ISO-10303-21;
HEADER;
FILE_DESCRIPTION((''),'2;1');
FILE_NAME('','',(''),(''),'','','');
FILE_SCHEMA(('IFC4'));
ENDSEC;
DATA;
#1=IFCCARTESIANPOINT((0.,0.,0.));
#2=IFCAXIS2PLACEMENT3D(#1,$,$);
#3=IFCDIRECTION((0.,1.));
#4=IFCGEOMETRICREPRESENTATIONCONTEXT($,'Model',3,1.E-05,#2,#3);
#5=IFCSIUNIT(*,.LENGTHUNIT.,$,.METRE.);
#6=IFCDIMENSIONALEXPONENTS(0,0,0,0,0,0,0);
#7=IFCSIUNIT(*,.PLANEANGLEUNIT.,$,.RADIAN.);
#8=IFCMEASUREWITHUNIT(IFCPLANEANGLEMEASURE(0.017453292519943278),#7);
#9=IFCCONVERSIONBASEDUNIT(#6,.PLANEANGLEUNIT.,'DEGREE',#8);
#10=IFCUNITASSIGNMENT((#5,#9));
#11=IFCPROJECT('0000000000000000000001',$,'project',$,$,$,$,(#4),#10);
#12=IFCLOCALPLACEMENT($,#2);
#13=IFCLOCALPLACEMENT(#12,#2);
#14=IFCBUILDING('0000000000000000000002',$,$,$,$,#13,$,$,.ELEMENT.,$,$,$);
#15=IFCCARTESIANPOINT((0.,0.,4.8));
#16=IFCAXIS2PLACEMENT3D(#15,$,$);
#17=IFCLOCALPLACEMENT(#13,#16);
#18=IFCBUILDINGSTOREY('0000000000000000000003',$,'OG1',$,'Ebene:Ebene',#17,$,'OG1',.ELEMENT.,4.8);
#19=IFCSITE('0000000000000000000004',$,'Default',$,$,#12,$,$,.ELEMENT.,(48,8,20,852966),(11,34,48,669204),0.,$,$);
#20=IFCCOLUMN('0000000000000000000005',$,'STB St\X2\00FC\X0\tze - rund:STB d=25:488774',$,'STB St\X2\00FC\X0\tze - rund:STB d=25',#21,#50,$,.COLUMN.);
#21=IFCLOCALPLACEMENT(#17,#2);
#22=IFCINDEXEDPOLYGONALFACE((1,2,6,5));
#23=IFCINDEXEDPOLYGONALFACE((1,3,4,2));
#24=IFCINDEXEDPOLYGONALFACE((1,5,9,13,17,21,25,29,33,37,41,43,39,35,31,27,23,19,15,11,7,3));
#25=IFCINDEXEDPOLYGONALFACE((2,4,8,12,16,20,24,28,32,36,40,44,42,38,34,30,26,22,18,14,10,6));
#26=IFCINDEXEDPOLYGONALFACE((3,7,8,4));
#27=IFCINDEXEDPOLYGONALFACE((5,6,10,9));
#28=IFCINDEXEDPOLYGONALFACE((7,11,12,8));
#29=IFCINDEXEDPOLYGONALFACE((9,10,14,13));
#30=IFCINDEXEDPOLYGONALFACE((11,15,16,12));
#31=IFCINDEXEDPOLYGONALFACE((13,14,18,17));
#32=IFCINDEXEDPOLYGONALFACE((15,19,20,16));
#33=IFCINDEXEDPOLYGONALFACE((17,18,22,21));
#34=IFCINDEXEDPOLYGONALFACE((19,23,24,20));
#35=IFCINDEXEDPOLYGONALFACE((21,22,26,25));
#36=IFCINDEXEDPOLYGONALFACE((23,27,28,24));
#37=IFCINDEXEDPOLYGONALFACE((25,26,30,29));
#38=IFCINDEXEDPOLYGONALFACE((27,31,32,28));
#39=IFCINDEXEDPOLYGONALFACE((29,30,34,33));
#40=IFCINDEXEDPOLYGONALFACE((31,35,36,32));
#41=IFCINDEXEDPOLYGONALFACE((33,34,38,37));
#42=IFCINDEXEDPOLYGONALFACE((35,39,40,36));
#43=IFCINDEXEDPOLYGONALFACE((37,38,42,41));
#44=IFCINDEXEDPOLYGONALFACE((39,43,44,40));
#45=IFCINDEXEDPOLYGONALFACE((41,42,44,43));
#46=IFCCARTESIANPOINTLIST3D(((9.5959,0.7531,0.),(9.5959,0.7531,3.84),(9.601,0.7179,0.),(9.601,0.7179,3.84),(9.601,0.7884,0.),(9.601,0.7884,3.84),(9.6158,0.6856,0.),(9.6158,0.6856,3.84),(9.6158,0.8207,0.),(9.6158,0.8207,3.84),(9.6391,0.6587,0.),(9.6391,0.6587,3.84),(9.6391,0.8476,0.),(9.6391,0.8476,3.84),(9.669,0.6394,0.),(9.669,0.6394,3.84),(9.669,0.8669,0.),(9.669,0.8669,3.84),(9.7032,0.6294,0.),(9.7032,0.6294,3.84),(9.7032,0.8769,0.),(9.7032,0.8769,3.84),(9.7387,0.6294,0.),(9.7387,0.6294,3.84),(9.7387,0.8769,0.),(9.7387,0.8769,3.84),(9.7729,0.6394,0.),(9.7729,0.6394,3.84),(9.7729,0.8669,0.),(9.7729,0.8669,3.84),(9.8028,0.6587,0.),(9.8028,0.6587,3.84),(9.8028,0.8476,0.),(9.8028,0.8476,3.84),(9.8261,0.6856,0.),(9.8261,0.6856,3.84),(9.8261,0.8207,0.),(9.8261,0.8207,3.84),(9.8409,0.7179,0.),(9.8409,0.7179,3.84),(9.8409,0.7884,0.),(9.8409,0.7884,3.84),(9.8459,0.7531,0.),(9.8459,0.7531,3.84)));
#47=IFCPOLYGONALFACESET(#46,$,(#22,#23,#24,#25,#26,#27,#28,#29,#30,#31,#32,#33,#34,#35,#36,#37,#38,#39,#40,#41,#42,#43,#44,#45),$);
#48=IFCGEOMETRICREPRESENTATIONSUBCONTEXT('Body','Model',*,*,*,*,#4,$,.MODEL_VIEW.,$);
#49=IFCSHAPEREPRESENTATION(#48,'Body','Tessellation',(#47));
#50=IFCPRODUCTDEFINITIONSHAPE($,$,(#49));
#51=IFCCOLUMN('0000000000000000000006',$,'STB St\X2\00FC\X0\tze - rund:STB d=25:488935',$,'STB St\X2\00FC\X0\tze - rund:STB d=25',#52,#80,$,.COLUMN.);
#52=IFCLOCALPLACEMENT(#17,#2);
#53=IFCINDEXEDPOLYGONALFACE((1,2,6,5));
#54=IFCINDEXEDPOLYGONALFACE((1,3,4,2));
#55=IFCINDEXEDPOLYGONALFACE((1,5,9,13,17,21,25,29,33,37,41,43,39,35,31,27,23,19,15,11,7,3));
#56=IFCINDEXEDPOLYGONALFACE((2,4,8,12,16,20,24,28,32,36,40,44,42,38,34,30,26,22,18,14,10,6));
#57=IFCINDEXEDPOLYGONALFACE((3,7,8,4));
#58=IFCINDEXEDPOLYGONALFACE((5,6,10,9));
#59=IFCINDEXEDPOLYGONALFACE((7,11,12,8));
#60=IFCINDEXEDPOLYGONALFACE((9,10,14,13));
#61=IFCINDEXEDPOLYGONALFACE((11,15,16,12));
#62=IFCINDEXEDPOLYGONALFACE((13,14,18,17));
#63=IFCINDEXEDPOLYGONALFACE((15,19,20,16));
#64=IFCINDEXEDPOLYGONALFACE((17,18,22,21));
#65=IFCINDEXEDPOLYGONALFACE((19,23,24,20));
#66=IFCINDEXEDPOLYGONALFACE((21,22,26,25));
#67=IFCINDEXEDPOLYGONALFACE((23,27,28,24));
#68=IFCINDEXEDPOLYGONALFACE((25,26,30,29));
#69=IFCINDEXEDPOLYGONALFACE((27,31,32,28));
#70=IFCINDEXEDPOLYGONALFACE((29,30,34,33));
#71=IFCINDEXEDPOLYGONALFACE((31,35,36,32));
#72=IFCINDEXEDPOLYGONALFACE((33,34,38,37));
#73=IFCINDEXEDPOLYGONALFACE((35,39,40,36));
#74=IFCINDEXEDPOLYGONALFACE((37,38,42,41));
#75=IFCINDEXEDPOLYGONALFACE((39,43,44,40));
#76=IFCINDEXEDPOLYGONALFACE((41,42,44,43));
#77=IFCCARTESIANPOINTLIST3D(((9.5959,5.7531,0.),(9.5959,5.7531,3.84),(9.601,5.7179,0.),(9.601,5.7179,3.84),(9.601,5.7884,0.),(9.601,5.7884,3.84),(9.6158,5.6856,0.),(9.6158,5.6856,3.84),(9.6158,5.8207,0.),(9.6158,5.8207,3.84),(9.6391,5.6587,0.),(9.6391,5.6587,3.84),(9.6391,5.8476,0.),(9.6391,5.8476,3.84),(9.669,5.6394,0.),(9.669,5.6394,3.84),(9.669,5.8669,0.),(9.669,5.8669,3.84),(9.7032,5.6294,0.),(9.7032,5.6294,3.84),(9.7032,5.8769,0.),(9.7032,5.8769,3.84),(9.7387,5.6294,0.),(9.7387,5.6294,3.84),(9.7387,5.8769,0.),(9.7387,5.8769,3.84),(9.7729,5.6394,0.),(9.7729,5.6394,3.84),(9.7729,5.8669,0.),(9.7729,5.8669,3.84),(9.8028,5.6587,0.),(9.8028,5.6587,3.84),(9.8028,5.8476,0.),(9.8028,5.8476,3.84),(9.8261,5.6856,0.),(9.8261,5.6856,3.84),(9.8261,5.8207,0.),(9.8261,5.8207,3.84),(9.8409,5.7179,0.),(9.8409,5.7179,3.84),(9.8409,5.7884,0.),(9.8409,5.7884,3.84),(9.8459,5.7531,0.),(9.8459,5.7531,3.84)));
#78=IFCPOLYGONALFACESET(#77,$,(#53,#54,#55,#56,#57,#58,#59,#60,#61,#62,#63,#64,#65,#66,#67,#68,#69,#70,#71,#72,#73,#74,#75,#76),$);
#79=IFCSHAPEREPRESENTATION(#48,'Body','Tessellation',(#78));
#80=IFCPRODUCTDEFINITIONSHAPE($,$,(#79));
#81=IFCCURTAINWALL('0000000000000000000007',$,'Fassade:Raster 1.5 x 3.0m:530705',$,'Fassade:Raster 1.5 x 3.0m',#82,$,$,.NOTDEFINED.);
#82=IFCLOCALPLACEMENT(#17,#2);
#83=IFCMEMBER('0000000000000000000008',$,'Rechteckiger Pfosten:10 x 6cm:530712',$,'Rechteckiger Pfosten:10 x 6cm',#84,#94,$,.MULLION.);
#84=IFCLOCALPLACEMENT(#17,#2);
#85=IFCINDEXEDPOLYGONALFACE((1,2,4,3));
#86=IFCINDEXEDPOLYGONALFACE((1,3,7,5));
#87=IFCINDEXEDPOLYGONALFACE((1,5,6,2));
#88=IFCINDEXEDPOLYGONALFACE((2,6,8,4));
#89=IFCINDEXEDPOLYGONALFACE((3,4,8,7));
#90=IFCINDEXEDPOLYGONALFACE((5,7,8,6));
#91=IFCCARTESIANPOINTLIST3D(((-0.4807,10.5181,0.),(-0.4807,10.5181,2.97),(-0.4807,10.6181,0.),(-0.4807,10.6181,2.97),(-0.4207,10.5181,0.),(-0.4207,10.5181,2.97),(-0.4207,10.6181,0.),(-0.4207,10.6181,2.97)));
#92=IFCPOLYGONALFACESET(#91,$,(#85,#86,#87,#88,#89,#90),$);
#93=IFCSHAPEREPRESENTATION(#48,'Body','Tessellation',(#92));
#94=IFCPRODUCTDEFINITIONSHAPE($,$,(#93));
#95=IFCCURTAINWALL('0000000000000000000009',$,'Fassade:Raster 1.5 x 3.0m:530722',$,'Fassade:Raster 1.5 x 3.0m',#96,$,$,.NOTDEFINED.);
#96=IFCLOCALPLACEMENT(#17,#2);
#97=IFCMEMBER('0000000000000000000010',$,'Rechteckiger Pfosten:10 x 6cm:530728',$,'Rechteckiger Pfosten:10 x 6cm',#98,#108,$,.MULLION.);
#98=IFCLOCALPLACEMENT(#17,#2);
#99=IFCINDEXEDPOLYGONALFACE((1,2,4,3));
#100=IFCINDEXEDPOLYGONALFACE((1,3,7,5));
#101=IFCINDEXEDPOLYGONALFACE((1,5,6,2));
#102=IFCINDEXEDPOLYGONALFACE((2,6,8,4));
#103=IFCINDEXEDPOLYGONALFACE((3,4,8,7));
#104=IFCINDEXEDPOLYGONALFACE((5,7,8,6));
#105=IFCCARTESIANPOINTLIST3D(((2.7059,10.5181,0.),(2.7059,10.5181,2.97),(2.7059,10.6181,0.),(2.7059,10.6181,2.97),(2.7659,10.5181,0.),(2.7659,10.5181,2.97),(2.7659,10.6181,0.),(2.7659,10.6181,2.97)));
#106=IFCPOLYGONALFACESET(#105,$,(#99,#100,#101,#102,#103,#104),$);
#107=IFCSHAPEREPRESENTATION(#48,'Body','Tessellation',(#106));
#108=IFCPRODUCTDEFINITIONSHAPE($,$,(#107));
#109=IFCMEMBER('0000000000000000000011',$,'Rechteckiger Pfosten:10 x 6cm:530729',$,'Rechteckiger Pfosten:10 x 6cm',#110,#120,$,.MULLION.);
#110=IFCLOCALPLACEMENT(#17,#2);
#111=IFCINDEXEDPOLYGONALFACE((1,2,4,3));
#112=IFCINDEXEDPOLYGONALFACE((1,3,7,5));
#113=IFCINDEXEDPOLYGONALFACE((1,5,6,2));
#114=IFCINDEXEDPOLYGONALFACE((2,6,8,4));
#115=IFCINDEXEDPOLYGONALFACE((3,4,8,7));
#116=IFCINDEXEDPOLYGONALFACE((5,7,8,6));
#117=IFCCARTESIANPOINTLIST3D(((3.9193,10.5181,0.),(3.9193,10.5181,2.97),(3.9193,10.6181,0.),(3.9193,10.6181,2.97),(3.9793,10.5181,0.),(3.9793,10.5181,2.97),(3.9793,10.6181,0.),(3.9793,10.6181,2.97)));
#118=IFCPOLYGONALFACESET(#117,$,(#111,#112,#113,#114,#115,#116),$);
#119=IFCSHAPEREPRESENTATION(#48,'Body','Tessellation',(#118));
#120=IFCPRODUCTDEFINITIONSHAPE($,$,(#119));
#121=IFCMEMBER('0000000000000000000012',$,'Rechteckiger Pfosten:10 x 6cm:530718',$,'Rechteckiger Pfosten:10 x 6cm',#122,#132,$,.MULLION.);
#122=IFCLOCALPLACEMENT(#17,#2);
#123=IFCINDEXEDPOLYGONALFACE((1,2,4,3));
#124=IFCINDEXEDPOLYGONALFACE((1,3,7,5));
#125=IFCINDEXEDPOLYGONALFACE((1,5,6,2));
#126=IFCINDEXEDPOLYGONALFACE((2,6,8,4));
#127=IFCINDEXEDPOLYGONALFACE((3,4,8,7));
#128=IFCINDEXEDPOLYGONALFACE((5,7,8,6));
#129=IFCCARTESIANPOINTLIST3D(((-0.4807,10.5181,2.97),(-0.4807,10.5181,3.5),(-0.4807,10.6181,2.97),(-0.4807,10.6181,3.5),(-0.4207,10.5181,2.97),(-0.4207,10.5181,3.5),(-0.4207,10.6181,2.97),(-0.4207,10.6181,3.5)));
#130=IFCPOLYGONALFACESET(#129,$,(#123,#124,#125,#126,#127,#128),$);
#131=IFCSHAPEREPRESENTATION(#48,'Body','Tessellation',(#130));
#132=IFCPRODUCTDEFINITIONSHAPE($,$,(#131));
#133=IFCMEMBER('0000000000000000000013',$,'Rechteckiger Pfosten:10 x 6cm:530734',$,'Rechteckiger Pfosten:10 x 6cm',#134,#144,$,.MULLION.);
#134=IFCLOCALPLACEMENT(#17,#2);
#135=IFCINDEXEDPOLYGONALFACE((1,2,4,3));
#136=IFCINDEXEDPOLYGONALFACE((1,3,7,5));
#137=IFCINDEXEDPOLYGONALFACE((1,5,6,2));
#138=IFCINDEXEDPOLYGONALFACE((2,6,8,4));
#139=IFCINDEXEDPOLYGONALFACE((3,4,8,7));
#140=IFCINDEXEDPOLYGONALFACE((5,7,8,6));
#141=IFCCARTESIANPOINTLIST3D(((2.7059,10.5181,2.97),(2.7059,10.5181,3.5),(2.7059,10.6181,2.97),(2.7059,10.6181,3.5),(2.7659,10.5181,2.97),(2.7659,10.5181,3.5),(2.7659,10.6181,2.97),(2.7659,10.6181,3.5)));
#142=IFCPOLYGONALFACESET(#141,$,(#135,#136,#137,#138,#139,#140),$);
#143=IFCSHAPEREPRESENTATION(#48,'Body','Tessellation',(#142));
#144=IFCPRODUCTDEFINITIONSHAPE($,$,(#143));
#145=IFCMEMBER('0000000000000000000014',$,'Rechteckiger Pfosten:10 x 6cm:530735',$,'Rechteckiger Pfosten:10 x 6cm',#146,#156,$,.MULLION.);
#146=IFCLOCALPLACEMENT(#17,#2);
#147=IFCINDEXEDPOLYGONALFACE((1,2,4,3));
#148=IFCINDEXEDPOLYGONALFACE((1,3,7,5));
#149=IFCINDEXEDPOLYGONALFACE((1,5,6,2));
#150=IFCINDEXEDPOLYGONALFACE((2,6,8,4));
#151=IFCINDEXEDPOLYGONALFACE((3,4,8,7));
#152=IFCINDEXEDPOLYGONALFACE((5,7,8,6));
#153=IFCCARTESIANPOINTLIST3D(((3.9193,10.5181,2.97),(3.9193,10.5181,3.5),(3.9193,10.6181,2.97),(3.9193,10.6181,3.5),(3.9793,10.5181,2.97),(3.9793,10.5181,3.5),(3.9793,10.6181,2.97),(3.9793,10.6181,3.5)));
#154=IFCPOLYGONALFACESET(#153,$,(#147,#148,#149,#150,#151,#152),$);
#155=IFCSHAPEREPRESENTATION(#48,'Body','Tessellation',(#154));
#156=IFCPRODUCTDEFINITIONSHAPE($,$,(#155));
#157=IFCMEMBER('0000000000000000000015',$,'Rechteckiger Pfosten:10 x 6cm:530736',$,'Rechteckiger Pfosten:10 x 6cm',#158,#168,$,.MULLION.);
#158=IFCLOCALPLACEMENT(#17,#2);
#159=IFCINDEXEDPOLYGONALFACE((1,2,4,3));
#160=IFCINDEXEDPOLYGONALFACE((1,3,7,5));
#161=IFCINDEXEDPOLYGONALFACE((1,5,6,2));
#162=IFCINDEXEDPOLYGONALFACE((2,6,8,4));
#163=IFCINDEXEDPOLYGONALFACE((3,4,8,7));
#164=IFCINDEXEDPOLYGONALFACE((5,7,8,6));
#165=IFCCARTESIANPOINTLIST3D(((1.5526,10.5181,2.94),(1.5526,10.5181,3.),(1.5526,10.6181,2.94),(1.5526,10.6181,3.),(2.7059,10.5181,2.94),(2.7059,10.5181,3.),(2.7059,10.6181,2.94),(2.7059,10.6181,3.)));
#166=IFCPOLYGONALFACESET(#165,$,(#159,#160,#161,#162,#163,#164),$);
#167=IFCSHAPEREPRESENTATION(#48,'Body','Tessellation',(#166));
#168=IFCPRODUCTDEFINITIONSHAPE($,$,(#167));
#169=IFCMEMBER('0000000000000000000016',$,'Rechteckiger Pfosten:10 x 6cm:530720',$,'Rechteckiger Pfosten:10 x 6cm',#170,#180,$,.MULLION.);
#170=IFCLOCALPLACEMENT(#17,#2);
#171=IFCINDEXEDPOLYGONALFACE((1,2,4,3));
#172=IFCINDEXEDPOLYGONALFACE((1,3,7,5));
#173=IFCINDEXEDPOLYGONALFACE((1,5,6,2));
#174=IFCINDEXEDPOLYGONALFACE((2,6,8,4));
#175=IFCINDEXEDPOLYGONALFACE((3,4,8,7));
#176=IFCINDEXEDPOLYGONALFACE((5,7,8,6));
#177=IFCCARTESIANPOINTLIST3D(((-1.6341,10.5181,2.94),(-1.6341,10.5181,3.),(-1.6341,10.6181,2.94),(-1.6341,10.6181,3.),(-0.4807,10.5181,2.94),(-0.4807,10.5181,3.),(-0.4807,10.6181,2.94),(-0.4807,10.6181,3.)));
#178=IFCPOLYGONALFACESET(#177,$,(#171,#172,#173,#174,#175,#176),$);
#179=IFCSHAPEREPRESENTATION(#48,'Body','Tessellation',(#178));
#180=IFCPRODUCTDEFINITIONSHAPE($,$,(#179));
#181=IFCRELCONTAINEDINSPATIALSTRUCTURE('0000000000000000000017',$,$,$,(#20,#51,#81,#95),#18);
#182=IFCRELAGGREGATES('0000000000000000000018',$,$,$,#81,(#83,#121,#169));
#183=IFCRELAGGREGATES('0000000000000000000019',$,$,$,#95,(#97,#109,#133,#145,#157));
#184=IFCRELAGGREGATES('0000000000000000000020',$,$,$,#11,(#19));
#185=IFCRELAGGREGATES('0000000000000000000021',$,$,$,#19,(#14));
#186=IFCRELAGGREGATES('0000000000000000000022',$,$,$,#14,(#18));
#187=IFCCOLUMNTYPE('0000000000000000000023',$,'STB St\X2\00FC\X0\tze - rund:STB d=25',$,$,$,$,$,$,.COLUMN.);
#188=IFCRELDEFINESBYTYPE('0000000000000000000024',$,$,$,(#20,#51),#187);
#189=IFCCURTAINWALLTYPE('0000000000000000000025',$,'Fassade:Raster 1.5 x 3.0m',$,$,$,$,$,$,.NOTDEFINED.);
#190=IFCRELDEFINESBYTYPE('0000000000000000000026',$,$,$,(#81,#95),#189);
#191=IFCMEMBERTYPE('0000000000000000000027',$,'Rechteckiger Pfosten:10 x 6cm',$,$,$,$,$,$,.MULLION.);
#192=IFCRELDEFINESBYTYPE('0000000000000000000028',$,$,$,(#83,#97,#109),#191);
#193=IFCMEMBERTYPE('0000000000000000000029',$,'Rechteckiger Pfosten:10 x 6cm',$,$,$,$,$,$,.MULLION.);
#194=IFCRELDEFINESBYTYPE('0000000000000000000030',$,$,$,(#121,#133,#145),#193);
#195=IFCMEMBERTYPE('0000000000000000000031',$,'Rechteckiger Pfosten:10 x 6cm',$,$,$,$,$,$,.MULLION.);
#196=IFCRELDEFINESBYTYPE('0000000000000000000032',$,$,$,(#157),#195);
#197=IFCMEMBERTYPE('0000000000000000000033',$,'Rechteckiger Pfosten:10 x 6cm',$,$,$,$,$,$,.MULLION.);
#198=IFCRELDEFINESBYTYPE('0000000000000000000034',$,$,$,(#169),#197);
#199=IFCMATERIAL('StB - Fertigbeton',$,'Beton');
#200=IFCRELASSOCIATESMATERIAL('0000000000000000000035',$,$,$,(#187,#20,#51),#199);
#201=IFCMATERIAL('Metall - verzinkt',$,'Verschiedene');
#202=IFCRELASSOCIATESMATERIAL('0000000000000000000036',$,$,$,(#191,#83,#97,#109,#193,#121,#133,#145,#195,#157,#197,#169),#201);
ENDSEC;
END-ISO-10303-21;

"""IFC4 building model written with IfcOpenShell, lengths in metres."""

from ifc_helpers import new_model, entity, si_unit, converted_unit, direction, frame, origin, place, context, subcontext, project, spatial, arc, indexed_curve, outline, extrude, source, transform, mapped, material, type_object, type_shapes, element, aggregate, save


model = new_model("IFC4")

# Units and contexts
model_context = context("Model", 3, precision=1e-05, world=origin(), true_north=direction((0.0, 1.0)))
body_context = subcontext(model_context, "Body", "Model", "MODEL_VIEW")
ifc_project = project(units=[si_unit("LENGTHUNIT", "METRE"), converted_unit("PLANEANGLEUNIT", "DEGREE", entity("IfcPlaneAngleMeasure", 0.017453292519943278), si_unit("PLANEANGLEUNIT", "RADIAN"), dimensions=[0, 0, 0, 0, 0, 0, 0])], contexts=[model_context])

# Site, building, storey
site_placement = place(None, origin())
site = spatial("IfcSite", under=ifc_project, at=site_placement, Name="Default", CompositionType="ELEMENT", RefLatitude=(48, 8, 20, 852966), RefLongitude=(11, 34, 48, 669204), RefElevation=0.0)
building_placement = place(site_placement, origin())
building = spatial("IfcBuilding", under=site, at=building_placement, CompositionType="ELEMENT")
storey_placement = place(building_placement, frame((0.0, 0.0, 4.8)))
storey = spatial("IfcBuildingStorey", under=building, at=storey_placement, Name="OG1", ObjectType="Ebene:Ebene", LongName="OG1", CompositionType="ELEMENT", Elevation=4.8)

# Columns
ifc_material_1 = material(Name="StB - Fertigbeton", Category="Beton")
column_type = type_object("IfcColumnType", Name="STB Stütze - rund:STB d=25", PredefinedType="COLUMN", material=ifc_material_1)
shared_shape_1 = source(origin(), body_context, "Body", "SweptSolid", [
    extrude(outline(indexed_curve([(-0.125, 0.0), (0.0, -0.125), (0.125, 0.0), (0.0, 0.125)], segments=[arc(1, 2, 3), arc(3, 4, 1)], self_intersect=False)), frame((0.0, 0.0, 4.8)), (0.0, 0.0, 1.0), 3.84),
])
type_shapes(column_type, [shared_shape_1])
for number, where, name in (
    (1, (9.7209, 0.7531, -4.8), "STB Stütze - rund:STB d=25:488774"),
    (2, (9.7209, 5.7531, -4.8), "STB Stütze - rund:STB d=25:488935"),
):
    element("IfcColumn", number, at=place(storey_placement, frame(where)), inside=storey, type_object=column_type, material=ifc_material_1, Name=name, ObjectType="STB Stütze - rund:STB d=25", PredefinedType="COLUMN", context=body_context, shape_type="MappedRepresentation", body=[
        mapped(shared_shape_1, transform((0.0, 0.0, 0.0), scale=1.0)),
    ])

# Curtain wall, member
curtain_wall_type = type_object("IfcCurtainWallType", Name="Fassade:Raster 1.5 x 3.0m", PredefinedType="NOTDEFINED")
curtain_wall_1_placement = place(storey_placement, frame((0.0, 0.0, -4.8)))
curtain_wall_1 = element("IfcCurtainWall", 3, at=curtain_wall_1_placement, inside=storey, type_object=curtain_wall_type, Name="Fassade:Raster 1.5 x 3.0m:530705", ObjectType="Fassade:Raster 1.5 x 3.0m", PredefinedType="NOTDEFINED")
ifc_material_2 = material(Name="Metall - verzinkt", Category="Verschiedene")
member_type_1 = type_object("IfcMemberType", Name="Rechteckiger Pfosten:10 x 6cm", PredefinedType="MULLION", material=ifc_material_2)
shared_shape_2 = source(origin(), body_context, "Body", "SweptSolid", [
    extrude(outline(indexed_curve([(-0.03, -0.05), (0.03, -0.05), (0.03, 0.05), (-0.03, 0.05), (-0.03, -0.05)], self_intersect=False)), frame((0.0, 0.0, -2.97), z_axis=(0.0, 0.0, 1.0), x_axis=(-1.0, 0.0, 0.0)), (0.0, 0.0, 1.0), 2.97),
])
type_shapes(member_type_1, [shared_shape_2])
member_1_placement = place(curtain_wall_1_placement, frame((-0.4507, 10.5681, 4.8), z_axis=(0.0, 0.0, -1.0), x_axis=(1.0, 0.0, 0.0)))
member_1 = element("IfcMember", 4, at=member_1_placement, type_object=member_type_1, material=ifc_material_2, Name="Rechteckiger Pfosten:10 x 6cm:530712", ObjectType="Rechteckiger Pfosten:10 x 6cm", PredefinedType="MULLION", context=body_context, shape_type="MappedRepresentation", body=[
    mapped(shared_shape_2, transform((0.0, 0.0, 0.0), scale=1.0)),
])

# Curtain wall, members
curtain_wall_2_placement = place(storey_placement, frame((0.0, 0.0, -4.8)))
curtain_wall_2 = element("IfcCurtainWall", 5, at=curtain_wall_2_placement, inside=storey, type_object=curtain_wall_type, Name="Fassade:Raster 1.5 x 3.0m:530722", ObjectType="Fassade:Raster 1.5 x 3.0m", PredefinedType="NOTDEFINED")
member_2_placement = place(curtain_wall_2_placement, frame((2.7359, 10.5681, 4.8), z_axis=(0.0, 0.0, -1.0), x_axis=(1.0, 0.0, 0.0)))
member_2 = element("IfcMember", 6, at=member_2_placement, type_object=member_type_1, material=ifc_material_2, Name="Rechteckiger Pfosten:10 x 6cm:530728", ObjectType="Rechteckiger Pfosten:10 x 6cm", PredefinedType="MULLION", context=body_context, shape_type="MappedRepresentation", body=[
    mapped(shared_shape_2, transform((0.0, 0.0, 0.0), scale=1.0)),
])
member_3_placement = place(curtain_wall_2_placement, frame((3.9493, 10.5681, 4.8), z_axis=(0.0, 0.0, -1.0), x_axis=(1.0, 0.0, 0.0)))
member_3 = element("IfcMember", 7, at=member_3_placement, type_object=member_type_1, material=ifc_material_2, Name="Rechteckiger Pfosten:10 x 6cm:530729", ObjectType="Rechteckiger Pfosten:10 x 6cm", PredefinedType="MULLION", context=body_context, shape_type="MappedRepresentation", body=[
    mapped(shared_shape_2, transform((0.0, 0.0, 0.0), scale=1.0)),
])

# Members
member_type_2 = type_object("IfcMemberType", Name="Rechteckiger Pfosten:10 x 6cm", PredefinedType="MULLION", material=ifc_material_2)
shared_shape_3 = source(origin(), body_context, "Body", "SweptSolid", [
    extrude(outline(indexed_curve([(-0.03, -0.05), (0.03, -0.05), (0.03, 0.05), (-0.03, 0.05), (-0.03, -0.05)], self_intersect=False)), frame((0.0, 0.0, -0.53), z_axis=(0.0, 0.0, 1.0), x_axis=(-1.0, 0.0, 0.0)), (0.0, 0.0, 1.0), 0.53),
])
type_shapes(member_type_2, [shared_shape_3])
member_4_placement = place(curtain_wall_1_placement, frame((-0.4507, 10.5681, 7.77), z_axis=(0.0, 0.0, -1.0), x_axis=(1.0, 0.0, 0.0)))
member_4 = element("IfcMember", 8, at=member_4_placement, type_object=member_type_2, material=ifc_material_2, Name="Rechteckiger Pfosten:10 x 6cm:530718", ObjectType="Rechteckiger Pfosten:10 x 6cm", PredefinedType="MULLION", context=body_context, shape_type="MappedRepresentation", body=[
    mapped(shared_shape_3, transform((0.0, 0.0, 0.0), scale=1.0)),
])
member_5_placement = place(curtain_wall_2_placement, frame((2.7359, 10.5681, 7.77), z_axis=(0.0, 0.0, -1.0), x_axis=(1.0, 0.0, 0.0)))
member_5 = element("IfcMember", 9, at=member_5_placement, type_object=member_type_2, material=ifc_material_2, Name="Rechteckiger Pfosten:10 x 6cm:530734", ObjectType="Rechteckiger Pfosten:10 x 6cm", PredefinedType="MULLION", context=body_context, shape_type="MappedRepresentation", body=[
    mapped(shared_shape_3, transform((0.0, 0.0, 0.0), scale=1.0)),
])
member_6_placement = place(curtain_wall_2_placement, frame((3.9493, 10.5681, 7.77), z_axis=(0.0, 0.0, -1.0), x_axis=(1.0, 0.0, 0.0)))
member_6 = element("IfcMember", 10, at=member_6_placement, type_object=member_type_2, material=ifc_material_2, Name="Rechteckiger Pfosten:10 x 6cm:530735", ObjectType="Rechteckiger Pfosten:10 x 6cm", PredefinedType="MULLION", context=body_context, shape_type="MappedRepresentation", body=[
    mapped(shared_shape_3, transform((0.0, 0.0, 0.0), scale=1.0)),
])
member_type_3 = type_object("IfcMemberType", Name="Rechteckiger Pfosten:10 x 6cm", PredefinedType="MULLION", material=ifc_material_2)
shared_shape_4 = source(origin(), body_context, "Body", "SweptSolid", [
    extrude(outline(indexed_curve([(-0.03, -0.05), (0.03, -0.05), (0.03, 0.05), (-0.03, 0.05), (-0.03, -0.05)], self_intersect=False)), frame((0.0, 0.0, -1.1533), z_axis=(0.0, 0.0, 1.0), x_axis=(-1.0, 0.0, 0.0)), (0.0, 0.0, 1.0), 1.1533),
])
type_shapes(member_type_3, [shared_shape_4])
member_7_placement = place(curtain_wall_2_placement, frame((2.7059, 10.5681, 7.77), z_axis=(1.0, 0.0, 0.0), x_axis=(0.0, 0.0, 1.0)))
member_7 = element("IfcMember", 11, at=member_7_placement, type_object=member_type_3, material=ifc_material_2, Name="Rechteckiger Pfosten:10 x 6cm:530736", ObjectType="Rechteckiger Pfosten:10 x 6cm", PredefinedType="MULLION", context=body_context, shape_type="MappedRepresentation", body=[
    mapped(shared_shape_4, transform((0.0, 0.0, 0.0), scale=1.0)),
])
member_type_4 = type_object("IfcMemberType", Name="Rechteckiger Pfosten:10 x 6cm", PredefinedType="MULLION", material=ifc_material_2)
shared_shape_5 = source(origin(), body_context, "Body", "SweptSolid", [
    extrude(outline(indexed_curve([(-0.03, -0.05), (0.03, -0.05), (0.03, 0.05), (-0.03, 0.05), (-0.03, -0.05)], self_intersect=False)), frame((0.0, 0.0, -1.1533), z_axis=(0.0, 0.0, 1.0), x_axis=(-1.0, 0.0, 0.0)), (0.0, 0.0, 1.0), 1.1533),
])
type_shapes(member_type_4, [shared_shape_5])
member_8_placement = place(curtain_wall_1_placement, frame((-0.4807, 10.5681, 7.77), z_axis=(1.0, 0.0, 0.0), x_axis=(0.0, 0.0, 1.0)))
member_8 = element("IfcMember", 12, at=member_8_placement, type_object=member_type_4, material=ifc_material_2, Name="Rechteckiger Pfosten:10 x 6cm:530720", ObjectType="Rechteckiger Pfosten:10 x 6cm", PredefinedType="MULLION", context=body_context, shape_type="MappedRepresentation", body=[
    mapped(shared_shape_5, transform((0.0, 0.0, 0.0), scale=1.0)),
])

aggregate(curtain_wall_1, [member_1, member_4, member_8])
aggregate(curtain_wall_2, [member_2, member_3, member_5, member_6, member_7])

save(model, "model.ifc")
